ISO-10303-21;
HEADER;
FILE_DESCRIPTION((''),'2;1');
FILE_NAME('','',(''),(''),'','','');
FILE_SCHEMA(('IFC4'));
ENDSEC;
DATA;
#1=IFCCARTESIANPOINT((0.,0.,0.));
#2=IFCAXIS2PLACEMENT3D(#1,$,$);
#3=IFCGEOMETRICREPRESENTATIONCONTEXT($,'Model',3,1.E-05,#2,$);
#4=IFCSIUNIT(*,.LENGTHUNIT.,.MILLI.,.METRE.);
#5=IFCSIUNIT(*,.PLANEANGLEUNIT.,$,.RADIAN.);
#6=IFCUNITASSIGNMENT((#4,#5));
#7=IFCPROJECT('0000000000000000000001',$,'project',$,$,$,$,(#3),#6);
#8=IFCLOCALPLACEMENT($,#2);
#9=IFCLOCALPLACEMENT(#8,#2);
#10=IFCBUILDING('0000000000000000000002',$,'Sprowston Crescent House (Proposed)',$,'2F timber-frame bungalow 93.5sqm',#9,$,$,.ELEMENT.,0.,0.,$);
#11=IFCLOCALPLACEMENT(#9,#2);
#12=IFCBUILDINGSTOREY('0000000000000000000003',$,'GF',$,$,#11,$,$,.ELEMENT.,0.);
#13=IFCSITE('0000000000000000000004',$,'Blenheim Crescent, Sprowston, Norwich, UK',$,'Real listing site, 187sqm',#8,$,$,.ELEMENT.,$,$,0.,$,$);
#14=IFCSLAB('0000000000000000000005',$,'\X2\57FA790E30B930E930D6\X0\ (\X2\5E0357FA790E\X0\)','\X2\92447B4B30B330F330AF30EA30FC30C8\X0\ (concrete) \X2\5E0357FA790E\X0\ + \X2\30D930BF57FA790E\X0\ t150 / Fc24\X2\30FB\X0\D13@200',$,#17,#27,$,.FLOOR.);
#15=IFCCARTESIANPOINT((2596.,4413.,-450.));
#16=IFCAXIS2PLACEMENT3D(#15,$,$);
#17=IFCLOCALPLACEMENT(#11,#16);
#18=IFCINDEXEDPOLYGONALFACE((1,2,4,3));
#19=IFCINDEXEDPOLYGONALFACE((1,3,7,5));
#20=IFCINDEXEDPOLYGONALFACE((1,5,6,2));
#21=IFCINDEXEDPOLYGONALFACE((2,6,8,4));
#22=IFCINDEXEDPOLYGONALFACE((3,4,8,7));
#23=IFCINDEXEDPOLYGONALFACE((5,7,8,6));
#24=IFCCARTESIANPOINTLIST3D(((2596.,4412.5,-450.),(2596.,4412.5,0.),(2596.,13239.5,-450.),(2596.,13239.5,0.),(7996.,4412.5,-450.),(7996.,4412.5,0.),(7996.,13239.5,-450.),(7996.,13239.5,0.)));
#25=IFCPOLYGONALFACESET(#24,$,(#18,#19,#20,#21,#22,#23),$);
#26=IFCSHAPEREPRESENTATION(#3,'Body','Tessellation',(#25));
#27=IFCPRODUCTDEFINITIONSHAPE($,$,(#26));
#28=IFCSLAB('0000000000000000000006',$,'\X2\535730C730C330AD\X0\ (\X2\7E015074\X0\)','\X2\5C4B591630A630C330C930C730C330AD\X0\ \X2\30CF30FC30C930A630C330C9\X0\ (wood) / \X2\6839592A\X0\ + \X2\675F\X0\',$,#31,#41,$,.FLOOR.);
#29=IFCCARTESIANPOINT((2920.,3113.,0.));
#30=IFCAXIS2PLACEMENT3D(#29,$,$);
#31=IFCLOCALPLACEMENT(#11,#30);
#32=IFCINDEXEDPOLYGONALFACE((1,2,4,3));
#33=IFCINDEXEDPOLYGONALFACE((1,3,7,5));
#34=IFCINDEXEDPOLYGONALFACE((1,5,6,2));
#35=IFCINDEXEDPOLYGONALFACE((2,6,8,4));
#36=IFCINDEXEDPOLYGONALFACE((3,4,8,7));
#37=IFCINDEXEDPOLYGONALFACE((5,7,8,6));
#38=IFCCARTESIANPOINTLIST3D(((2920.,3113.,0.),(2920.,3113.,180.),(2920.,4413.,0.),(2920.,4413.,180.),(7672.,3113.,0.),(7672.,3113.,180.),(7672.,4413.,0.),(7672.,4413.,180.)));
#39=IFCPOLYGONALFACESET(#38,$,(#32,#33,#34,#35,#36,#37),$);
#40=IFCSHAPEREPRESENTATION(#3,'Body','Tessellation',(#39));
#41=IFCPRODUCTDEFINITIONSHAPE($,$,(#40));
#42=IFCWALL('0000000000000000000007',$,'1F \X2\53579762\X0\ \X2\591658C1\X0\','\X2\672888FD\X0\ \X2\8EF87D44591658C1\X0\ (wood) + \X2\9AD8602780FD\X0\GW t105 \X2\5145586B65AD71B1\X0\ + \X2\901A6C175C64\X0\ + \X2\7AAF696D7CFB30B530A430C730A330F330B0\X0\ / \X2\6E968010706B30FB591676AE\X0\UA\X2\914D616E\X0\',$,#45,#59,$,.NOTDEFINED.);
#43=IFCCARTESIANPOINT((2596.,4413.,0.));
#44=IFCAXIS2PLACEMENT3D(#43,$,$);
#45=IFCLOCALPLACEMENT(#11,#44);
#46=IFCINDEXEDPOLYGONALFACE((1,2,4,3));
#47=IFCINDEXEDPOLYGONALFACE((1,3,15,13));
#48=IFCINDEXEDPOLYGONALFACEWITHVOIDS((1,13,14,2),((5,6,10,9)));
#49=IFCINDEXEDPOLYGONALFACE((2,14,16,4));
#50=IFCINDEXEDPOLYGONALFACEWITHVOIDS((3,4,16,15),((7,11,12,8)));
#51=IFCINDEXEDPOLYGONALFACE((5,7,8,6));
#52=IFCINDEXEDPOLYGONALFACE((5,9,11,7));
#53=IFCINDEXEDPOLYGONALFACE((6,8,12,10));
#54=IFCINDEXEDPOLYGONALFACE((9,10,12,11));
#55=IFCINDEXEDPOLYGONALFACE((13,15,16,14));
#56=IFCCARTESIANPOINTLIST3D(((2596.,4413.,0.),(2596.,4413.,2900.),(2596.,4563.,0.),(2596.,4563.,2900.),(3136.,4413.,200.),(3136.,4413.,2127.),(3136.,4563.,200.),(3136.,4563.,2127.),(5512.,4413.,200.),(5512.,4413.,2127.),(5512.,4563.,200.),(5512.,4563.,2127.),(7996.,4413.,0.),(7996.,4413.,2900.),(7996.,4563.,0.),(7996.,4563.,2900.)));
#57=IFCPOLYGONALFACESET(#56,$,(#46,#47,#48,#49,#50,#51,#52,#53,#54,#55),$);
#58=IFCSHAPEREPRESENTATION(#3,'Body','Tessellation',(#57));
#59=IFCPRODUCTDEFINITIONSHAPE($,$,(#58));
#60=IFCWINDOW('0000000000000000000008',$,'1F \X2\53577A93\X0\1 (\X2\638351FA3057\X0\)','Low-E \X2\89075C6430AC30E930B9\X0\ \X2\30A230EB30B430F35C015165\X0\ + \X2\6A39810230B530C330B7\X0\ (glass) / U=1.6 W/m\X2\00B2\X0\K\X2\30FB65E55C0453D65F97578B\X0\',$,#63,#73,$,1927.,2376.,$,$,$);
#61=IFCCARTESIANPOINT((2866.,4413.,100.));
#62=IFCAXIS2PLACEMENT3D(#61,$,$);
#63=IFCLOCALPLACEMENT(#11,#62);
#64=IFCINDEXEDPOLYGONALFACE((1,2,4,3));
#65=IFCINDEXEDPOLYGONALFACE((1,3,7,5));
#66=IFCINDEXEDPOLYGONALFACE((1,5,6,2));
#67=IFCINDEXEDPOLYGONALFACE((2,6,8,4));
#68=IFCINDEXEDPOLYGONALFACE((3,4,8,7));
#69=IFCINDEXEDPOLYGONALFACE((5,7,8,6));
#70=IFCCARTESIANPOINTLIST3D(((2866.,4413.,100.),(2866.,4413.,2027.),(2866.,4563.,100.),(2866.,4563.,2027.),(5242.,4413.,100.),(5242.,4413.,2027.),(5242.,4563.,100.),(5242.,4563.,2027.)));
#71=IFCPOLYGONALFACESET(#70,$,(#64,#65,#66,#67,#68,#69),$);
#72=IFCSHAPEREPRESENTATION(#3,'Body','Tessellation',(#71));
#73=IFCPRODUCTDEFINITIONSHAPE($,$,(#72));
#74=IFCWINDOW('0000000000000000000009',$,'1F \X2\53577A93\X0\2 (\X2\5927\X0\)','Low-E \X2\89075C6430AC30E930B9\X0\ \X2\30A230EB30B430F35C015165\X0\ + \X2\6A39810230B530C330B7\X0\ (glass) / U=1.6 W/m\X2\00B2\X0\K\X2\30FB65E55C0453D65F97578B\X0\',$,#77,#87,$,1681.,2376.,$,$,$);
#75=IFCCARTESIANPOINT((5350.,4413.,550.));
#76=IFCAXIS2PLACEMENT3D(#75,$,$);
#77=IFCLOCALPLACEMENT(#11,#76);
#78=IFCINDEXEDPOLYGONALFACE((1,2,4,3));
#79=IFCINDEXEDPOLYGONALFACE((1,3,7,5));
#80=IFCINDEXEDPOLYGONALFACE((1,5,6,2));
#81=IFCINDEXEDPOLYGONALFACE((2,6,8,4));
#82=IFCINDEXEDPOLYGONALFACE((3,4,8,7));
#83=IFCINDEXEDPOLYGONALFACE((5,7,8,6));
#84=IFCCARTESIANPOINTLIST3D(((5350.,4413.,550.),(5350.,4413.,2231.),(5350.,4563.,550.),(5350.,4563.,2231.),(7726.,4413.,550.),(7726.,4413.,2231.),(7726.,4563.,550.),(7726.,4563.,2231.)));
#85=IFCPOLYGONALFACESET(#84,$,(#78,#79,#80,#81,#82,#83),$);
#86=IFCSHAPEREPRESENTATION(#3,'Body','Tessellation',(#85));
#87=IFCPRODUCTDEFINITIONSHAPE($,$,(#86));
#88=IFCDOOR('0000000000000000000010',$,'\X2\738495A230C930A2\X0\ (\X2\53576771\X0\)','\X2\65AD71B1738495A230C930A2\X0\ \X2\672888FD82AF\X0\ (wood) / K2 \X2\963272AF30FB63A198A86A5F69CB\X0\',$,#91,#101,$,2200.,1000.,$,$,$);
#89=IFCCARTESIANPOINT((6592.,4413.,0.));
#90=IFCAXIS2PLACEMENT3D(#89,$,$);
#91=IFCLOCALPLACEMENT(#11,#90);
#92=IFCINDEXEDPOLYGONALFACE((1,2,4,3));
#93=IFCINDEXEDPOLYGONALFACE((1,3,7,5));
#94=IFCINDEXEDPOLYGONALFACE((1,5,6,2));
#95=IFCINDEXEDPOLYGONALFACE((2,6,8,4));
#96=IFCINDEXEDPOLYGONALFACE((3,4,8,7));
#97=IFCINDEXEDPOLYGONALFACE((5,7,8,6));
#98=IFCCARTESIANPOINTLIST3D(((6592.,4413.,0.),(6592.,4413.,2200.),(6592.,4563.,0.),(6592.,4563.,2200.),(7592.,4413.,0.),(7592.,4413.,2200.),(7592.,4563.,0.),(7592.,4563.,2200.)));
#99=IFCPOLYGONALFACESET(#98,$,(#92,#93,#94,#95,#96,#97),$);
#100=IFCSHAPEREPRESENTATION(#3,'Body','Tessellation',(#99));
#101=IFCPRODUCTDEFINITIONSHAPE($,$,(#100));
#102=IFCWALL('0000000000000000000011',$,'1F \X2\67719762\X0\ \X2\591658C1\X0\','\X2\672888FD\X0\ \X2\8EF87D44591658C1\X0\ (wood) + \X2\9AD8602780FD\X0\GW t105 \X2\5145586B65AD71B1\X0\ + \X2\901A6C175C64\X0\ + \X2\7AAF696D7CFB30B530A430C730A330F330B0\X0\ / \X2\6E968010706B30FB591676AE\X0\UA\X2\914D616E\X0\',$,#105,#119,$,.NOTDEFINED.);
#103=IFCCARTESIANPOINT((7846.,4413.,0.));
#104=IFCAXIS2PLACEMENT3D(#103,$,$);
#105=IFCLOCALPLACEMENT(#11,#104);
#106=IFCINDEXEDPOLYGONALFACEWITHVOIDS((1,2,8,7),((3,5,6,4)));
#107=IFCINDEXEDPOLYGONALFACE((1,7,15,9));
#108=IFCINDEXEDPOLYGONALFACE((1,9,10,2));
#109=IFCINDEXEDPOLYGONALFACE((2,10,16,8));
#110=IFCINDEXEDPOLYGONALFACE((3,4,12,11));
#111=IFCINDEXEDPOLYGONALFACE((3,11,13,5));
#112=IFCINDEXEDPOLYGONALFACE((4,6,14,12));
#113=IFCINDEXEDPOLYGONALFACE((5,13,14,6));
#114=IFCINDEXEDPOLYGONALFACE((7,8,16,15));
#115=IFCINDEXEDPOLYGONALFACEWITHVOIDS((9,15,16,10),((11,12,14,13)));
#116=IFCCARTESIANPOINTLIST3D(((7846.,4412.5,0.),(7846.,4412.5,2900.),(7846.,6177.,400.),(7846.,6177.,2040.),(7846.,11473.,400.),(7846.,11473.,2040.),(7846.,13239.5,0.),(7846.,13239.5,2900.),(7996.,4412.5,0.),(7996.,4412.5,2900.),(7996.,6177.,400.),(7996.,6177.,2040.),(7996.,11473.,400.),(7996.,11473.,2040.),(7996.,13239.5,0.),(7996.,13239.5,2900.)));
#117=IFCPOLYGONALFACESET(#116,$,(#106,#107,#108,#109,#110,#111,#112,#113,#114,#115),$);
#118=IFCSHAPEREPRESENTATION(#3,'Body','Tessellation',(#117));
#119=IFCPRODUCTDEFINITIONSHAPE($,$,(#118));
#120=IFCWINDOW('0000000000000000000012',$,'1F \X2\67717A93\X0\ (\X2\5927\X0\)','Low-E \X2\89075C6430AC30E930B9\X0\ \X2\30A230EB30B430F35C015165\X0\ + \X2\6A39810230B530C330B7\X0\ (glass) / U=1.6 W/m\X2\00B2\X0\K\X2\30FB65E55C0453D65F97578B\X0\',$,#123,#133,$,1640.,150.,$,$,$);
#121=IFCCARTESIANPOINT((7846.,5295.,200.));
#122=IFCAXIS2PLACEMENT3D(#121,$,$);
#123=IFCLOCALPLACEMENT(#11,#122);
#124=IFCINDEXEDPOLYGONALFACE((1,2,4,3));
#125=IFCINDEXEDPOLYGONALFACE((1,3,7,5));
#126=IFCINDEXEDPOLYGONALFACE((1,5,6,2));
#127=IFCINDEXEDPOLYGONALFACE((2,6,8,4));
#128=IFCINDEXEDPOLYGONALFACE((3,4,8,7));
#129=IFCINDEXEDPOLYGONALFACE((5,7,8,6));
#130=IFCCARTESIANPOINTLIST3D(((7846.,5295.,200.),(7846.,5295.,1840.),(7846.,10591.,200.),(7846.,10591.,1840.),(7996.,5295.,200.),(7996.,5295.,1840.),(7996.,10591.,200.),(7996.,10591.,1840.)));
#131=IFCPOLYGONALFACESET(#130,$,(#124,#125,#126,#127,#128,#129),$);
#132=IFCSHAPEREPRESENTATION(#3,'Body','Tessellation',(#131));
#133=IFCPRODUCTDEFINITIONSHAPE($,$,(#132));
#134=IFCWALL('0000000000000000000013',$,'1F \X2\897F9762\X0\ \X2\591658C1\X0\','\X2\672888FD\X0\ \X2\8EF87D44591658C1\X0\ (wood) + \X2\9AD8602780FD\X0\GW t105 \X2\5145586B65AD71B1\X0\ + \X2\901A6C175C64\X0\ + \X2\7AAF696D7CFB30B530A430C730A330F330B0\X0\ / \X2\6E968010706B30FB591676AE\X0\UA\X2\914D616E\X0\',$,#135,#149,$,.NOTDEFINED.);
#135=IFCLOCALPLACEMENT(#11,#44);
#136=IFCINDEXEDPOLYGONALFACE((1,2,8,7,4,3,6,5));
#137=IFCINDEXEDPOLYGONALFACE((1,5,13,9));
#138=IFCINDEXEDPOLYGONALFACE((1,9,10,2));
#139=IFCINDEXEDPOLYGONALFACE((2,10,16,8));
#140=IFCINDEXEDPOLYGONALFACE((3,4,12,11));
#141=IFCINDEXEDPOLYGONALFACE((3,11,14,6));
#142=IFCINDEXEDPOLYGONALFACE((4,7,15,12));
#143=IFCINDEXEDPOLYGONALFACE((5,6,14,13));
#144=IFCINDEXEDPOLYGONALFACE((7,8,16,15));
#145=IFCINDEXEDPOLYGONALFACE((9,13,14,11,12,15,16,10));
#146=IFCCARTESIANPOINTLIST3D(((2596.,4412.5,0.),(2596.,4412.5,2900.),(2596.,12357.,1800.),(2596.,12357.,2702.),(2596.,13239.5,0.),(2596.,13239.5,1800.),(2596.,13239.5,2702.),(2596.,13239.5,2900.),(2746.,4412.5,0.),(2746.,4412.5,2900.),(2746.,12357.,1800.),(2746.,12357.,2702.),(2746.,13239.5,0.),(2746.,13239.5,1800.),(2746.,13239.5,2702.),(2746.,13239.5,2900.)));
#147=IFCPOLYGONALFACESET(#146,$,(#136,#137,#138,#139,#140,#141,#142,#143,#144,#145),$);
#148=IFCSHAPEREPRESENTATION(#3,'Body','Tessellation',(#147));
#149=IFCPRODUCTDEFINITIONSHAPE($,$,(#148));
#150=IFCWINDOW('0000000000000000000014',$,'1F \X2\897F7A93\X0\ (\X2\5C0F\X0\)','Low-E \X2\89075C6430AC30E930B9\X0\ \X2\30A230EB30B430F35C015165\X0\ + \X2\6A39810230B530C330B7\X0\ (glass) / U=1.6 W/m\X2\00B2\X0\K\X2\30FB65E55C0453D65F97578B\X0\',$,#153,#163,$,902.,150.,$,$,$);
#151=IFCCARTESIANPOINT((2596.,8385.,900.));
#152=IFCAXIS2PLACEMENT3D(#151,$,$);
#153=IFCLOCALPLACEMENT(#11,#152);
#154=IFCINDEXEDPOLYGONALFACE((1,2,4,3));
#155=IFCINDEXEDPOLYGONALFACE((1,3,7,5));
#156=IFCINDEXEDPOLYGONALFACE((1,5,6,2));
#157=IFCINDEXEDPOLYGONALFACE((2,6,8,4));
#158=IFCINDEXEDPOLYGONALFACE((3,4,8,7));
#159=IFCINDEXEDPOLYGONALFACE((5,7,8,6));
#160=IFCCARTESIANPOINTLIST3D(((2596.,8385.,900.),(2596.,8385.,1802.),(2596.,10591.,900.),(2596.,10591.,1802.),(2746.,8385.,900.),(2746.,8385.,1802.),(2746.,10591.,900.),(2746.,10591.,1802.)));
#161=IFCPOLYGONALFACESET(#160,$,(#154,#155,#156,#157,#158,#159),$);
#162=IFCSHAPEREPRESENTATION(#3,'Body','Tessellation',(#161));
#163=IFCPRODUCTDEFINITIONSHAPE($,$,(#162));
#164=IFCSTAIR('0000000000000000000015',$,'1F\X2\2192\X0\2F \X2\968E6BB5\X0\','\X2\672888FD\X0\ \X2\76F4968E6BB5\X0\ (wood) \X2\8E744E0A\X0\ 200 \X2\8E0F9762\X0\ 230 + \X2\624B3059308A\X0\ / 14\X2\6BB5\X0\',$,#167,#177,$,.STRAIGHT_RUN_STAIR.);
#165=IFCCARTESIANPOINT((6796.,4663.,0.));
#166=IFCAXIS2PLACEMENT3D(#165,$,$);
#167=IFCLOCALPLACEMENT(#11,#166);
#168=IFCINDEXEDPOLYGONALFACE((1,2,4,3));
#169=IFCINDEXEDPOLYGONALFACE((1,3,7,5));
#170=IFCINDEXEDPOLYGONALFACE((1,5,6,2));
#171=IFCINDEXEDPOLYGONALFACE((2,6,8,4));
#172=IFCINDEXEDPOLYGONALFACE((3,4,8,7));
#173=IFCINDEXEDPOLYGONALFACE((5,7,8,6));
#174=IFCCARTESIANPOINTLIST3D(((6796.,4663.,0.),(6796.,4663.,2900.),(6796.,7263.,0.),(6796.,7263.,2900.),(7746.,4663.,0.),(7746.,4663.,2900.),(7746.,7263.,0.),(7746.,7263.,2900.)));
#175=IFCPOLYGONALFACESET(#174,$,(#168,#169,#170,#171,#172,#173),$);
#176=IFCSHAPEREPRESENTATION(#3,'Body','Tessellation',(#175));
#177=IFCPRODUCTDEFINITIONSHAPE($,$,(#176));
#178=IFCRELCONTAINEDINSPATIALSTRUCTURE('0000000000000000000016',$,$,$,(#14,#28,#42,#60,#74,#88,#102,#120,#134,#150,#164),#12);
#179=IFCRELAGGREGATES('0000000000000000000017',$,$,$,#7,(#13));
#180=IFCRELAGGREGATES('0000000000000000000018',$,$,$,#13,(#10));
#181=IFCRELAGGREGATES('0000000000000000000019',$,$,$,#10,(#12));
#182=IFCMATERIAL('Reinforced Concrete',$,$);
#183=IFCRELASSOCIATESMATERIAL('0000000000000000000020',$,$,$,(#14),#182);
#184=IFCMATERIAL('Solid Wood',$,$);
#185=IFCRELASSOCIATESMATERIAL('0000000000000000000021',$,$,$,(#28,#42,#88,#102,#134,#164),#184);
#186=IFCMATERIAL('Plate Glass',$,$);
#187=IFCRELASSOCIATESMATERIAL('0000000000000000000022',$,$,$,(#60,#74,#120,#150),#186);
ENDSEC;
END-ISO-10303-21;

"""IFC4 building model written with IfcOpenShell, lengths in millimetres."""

from ifc_helpers import new_model, si_unit, frame, frame_2d, origin, place, context, project, spatial, rectangle, extrude, material, element, fill, save


model = new_model("IFC4")

# Units and contexts
model_context = context("Model", 3, precision=1e-05, world=origin())
ifc_project = project(units=[si_unit("LENGTHUNIT", "METRE", prefix="MILLI"), si_unit("PLANEANGLEUNIT", "RADIAN")], contexts=[model_context])

# Site, building, storey
site_placement = place(None, origin())
site = spatial("IfcSite", under=ifc_project, at=site_placement, Name="Blenheim Crescent, Sprowston, Norwich, UK", ObjectType="Real listing site, 187sqm", CompositionType="ELEMENT", RefElevation=0.0)
building_placement = place(site_placement, origin())
building = spatial("IfcBuilding", under=site, at=building_placement, Name="Sprowston Crescent House (Proposed)", ObjectType="2F timber-frame bungalow 93.5sqm", CompositionType="ELEMENT", ElevationOfRefHeight=0.0, ElevationOfTerrain=0.0)
storey_placement = place(building_placement, origin())
storey = spatial("IfcBuildingStorey", under=building, at=storey_placement, Name="GF", CompositionType="ELEMENT", Elevation=0.0)

# Slabs
ifc_material_1 = material(Name="Reinforced Concrete")
slab_1_placement = place(storey_placement, frame((2596.0, 4413.0, -450.0)))
element("IfcSlab", 1, at=slab_1_placement, inside=storey, material=ifc_material_1, Name="基礎スラブ (布基礎)", Description="鉄筋コンクリート (concrete) 布基礎 + ベタ基礎 t150 / Fc24・D13@200", PredefinedType="FLOOR", context=model_context, shape_type="SweptSolid", body=[
    extrude(rectangle(XDim=5400.0, YDim=8827.0, at=frame_2d((2700.0, 4413.0))), frame((2596.0, 4413.0, -450.0)), (0.0, 0.0, 1.0), 450.0),
])
ifc_material_2 = material(Name="Solid Wood")
slab_2_placement = place(storey_placement, frame((2920.0, 3113.0, 0.0)))
element("IfcSlab", 2, at=slab_2_placement, inside=storey, material=ifc_material_2, Name="南デッキ (縁側)", Description="屋外ウッドデッキ ハードウッド (wood) / 根太 + 束", PredefinedType="FLOOR", context=model_context, shape_type="SweptSolid", body=[
    extrude(rectangle(XDim=4752.0, YDim=1300.0, at=frame_2d((2376.0, 650.0))), frame((2920.0, 3113.0, 0.0)), (0.0, 0.0, 1.0), 180.0),
])

# Wall, openings, windows, door
wall_1_placement = place(storey_placement, frame((2596.0, 4413.0, 0.0)))
wall_1 = element("IfcWall", 3, at=wall_1_placement, inside=storey, material=ifc_material_2, Name="1F 南面 外壁", Description="木製 軸組外壁 (wood) + 高性能GW t105 充填断熱 + 通気層 + 窯業系サイディング / 準耐火・外皮UA配慮", PredefinedType="NOTDEFINED", context=model_context, shape_type="SweptSolid", body=[
    extrude(rectangle(XDim=5400.0, YDim=150.0, at=frame_2d((2700.0, 75.0))), frame((2596.0, 4413.0, 0.0)), (0.0, 0.0, 1.0), 2900.0),
])
opening_1_placement = place(storey_placement, frame((2866.0, 4413.0, 100.0)))
opening_1 = element("IfcOpeningElement", 4, at=opening_1_placement, cuts=wall_1, PredefinedType="NOTDEFINED", context=model_context, shape_type="SweptSolid", body=[
    extrude(rectangle(XDim=2376.0, YDim=150.0, at=frame_2d((1188.0, 75.0))), frame((2866.0, 4413.0, 100.0)), (0.0, 0.0, 1.0), 1927.0),
])
opening_2_placement = place(storey_placement, frame((5350.0, 4413.0, 550.0)))
opening_2 = element("IfcOpeningElement", 5, at=opening_2_placement, cuts=wall_1, PredefinedType="NOTDEFINED", context=model_context, shape_type="SweptSolid", body=[
    extrude(rectangle(XDim=2376.0, YDim=150.0, at=frame_2d((1188.0, 75.0))), frame((5350.0, 4413.0, 550.0)), (0.0, 0.0, 1.0), 1681.0),
])
opening_3_placement = place(storey_placement, frame((6592.0, 4413.0, 0.0)))
opening_3 = element("IfcOpeningElement", 6, at=opening_3_placement, cuts=wall_1, PredefinedType="NOTDEFINED", context=model_context, shape_type="SweptSolid", body=[
    extrude(rectangle(XDim=1000.0, YDim=150.0, at=frame_2d((500.0, 75.0))), frame((6592.0, 4413.0, 0.0)), (0.0, 0.0, 1.0), 2200.0),
])
ifc_material_3 = material(Name="Plate Glass")
window_1_placement = place(storey_placement, frame((2866.0, 4413.0, 100.0)))
window_1 = element("IfcWindow", 7, at=window_1_placement, inside=storey, material=ifc_material_3, Name="1F 南窓1 (掃出し)", Description="Low-E 複層ガラス アルゴン封入 + 樹脂サッシ (glass) / U=1.6 W/m²K・日射取得型", OverallHeight=1927.0, OverallWidth=2376.0, context=model_context, shape_type="SweptSolid", body=[
    extrude(rectangle(XDim=2376.0, YDim=150.0, at=frame_2d((1188.0, 75.0))), frame((2866.0, 4413.0, 100.0)), (0.0, 0.0, 1.0), 1927.0),
])
fill(opening_1, window_1)
window_2_placement = place(storey_placement, frame((5350.0, 4413.0, 550.0)))
window_2 = element("IfcWindow", 8, at=window_2_placement, inside=storey, material=ifc_material_3, Name="1F 南窓2 (大)", Description="Low-E 複層ガラス アルゴン封入 + 樹脂サッシ (glass) / U=1.6 W/m²K・日射取得型", OverallHeight=1681.0, OverallWidth=2376.0, context=model_context, shape_type="SweptSolid", body=[
    extrude(rectangle(XDim=2376.0, YDim=150.0, at=frame_2d((1188.0, 75.0))), frame((5350.0, 4413.0, 550.0)), (0.0, 0.0, 1.0), 1681.0),
])
fill(opening_2, window_2)
door_placement = place(storey_placement, frame((6592.0, 4413.0, 0.0)))
door = element("IfcDoor", 9, at=door_placement, inside=storey, material=ifc_material_2, Name="玄関ドア (南東)", Description="断熱玄関ドア 木製芯 (wood) / K2 防犯・採風機構", OverallHeight=2200.0, OverallWidth=1000.0, context=model_context, shape_type="SweptSolid", body=[
    extrude(rectangle(XDim=1000.0, YDim=150.0, at=frame_2d((500.0, 75.0))), frame((6592.0, 4413.0, 0.0)), (0.0, 0.0, 1.0), 2200.0),
])
fill(opening_3, door)

# Walls, openings, windows
wall_2_placement = place(storey_placement, frame((7846.0, 4413.0, 0.0)))
wall_2 = element("IfcWall", 10, at=wall_2_placement, inside=storey, material=ifc_material_2, Name="1F 東面 外壁", Description="木製 軸組外壁 (wood) + 高性能GW t105 充填断熱 + 通気層 + 窯業系サイディング / 準耐火・外皮UA配慮", PredefinedType="NOTDEFINED", context=model_context, shape_type="SweptSolid", body=[
    extrude(rectangle(XDim=150.0, YDim=8827.0, at=frame_2d((75.0, 4413.0))), frame((7846.0, 4413.0, 0.0)), (0.0, 0.0, 1.0), 2900.0),
])
opening_4_placement = place(storey_placement, frame((7846.0, 5295.0, 200.0)))
opening_4 = element("IfcOpeningElement", 11, at=opening_4_placement, cuts=wall_2, PredefinedType="NOTDEFINED", context=model_context, shape_type="SweptSolid", body=[
    extrude(rectangle(XDim=150.0, YDim=5296.0, at=frame_2d((75.0, 2648.0))), frame((7846.0, 5295.0, 200.0)), (0.0, 0.0, 1.0), 1640.0),
])
window_3_placement = place(storey_placement, frame((7846.0, 5295.0, 200.0)))
window_3 = element("IfcWindow", 12, at=window_3_placement, inside=storey, material=ifc_material_3, Name="1F 東窓 (大)", Description="Low-E 複層ガラス アルゴン封入 + 樹脂サッシ (glass) / U=1.6 W/m²K・日射取得型", OverallHeight=1640.0, OverallWidth=150.0, context=model_context, shape_type="SweptSolid", body=[
    extrude(rectangle(XDim=150.0, YDim=5296.0, at=frame_2d((75.0, 2648.0))), frame((7846.0, 5295.0, 200.0)), (0.0, 0.0, 1.0), 1640.0),
])
fill(opening_4, window_3)
wall_3_placement = place(storey_placement, frame((2596.0, 4413.0, 0.0)))
wall_3 = element("IfcWall", 13, at=wall_3_placement, inside=storey, material=ifc_material_2, Name="1F 西面 外壁", Description="木製 軸組外壁 (wood) + 高性能GW t105 充填断熱 + 通気層 + 窯業系サイディング / 準耐火・外皮UA配慮", PredefinedType="NOTDEFINED", context=model_context, shape_type="SweptSolid", body=[
    extrude(rectangle(XDim=150.0, YDim=8827.0, at=frame_2d((75.0, 4413.0))), frame((2596.0, 4413.0, 0.0)), (0.0, 0.0, 1.0), 2900.0),
])
opening_5_placement = place(storey_placement, frame((2596.0, 8385.0, 900.0)))
opening_5 = element("IfcOpeningElement", 14, at=opening_5_placement, cuts=wall_3, PredefinedType="NOTDEFINED", context=model_context, shape_type="SweptSolid", body=[
    extrude(rectangle(XDim=150.0, YDim=2206.0, at=frame_2d((75.0, 1103.0))), frame((2596.0, 8385.0, 900.0)), (0.0, 0.0, 1.0), 902.0),
])
window_4_placement = place(storey_placement, frame((2596.0, 8385.0, 900.0)))
window_4 = element("IfcWindow", 15, at=window_4_placement, inside=storey, material=ifc_material_3, Name="1F 西窓 (小)", Description="Low-E 複層ガラス アルゴン封入 + 樹脂サッシ (glass) / U=1.6 W/m²K・日射取得型", OverallHeight=902.0, OverallWidth=150.0, context=model_context, shape_type="SweptSolid", body=[
    extrude(rectangle(XDim=150.0, YDim=2206.0, at=frame_2d((75.0, 1103.0))), frame((2596.0, 8385.0, 900.0)), (0.0, 0.0, 1.0), 902.0),
])
fill(opening_5, window_4)

# Stair
stair_placement = place(storey_placement, frame((6796.0, 4663.0, 0.0)))
element("IfcStair", 16, at=stair_placement, inside=storey, material=ifc_material_2, Name="1F→2F 階段", Description="木製 直階段 (wood) 蹴上 200 踏面 230 + 手すり / 14段", PredefinedType="STRAIGHT_RUN_STAIR", context=model_context, shape_type="SweptSolid", body=[
    extrude(rectangle(XDim=950.0, YDim=2600.0, at=frame_2d((475.0, 1300.0))), frame((6796.0, 4663.0, 0.0)), (0.0, 0.0, 1.0), 2900.0),
])

save(model, "model.ifc")
